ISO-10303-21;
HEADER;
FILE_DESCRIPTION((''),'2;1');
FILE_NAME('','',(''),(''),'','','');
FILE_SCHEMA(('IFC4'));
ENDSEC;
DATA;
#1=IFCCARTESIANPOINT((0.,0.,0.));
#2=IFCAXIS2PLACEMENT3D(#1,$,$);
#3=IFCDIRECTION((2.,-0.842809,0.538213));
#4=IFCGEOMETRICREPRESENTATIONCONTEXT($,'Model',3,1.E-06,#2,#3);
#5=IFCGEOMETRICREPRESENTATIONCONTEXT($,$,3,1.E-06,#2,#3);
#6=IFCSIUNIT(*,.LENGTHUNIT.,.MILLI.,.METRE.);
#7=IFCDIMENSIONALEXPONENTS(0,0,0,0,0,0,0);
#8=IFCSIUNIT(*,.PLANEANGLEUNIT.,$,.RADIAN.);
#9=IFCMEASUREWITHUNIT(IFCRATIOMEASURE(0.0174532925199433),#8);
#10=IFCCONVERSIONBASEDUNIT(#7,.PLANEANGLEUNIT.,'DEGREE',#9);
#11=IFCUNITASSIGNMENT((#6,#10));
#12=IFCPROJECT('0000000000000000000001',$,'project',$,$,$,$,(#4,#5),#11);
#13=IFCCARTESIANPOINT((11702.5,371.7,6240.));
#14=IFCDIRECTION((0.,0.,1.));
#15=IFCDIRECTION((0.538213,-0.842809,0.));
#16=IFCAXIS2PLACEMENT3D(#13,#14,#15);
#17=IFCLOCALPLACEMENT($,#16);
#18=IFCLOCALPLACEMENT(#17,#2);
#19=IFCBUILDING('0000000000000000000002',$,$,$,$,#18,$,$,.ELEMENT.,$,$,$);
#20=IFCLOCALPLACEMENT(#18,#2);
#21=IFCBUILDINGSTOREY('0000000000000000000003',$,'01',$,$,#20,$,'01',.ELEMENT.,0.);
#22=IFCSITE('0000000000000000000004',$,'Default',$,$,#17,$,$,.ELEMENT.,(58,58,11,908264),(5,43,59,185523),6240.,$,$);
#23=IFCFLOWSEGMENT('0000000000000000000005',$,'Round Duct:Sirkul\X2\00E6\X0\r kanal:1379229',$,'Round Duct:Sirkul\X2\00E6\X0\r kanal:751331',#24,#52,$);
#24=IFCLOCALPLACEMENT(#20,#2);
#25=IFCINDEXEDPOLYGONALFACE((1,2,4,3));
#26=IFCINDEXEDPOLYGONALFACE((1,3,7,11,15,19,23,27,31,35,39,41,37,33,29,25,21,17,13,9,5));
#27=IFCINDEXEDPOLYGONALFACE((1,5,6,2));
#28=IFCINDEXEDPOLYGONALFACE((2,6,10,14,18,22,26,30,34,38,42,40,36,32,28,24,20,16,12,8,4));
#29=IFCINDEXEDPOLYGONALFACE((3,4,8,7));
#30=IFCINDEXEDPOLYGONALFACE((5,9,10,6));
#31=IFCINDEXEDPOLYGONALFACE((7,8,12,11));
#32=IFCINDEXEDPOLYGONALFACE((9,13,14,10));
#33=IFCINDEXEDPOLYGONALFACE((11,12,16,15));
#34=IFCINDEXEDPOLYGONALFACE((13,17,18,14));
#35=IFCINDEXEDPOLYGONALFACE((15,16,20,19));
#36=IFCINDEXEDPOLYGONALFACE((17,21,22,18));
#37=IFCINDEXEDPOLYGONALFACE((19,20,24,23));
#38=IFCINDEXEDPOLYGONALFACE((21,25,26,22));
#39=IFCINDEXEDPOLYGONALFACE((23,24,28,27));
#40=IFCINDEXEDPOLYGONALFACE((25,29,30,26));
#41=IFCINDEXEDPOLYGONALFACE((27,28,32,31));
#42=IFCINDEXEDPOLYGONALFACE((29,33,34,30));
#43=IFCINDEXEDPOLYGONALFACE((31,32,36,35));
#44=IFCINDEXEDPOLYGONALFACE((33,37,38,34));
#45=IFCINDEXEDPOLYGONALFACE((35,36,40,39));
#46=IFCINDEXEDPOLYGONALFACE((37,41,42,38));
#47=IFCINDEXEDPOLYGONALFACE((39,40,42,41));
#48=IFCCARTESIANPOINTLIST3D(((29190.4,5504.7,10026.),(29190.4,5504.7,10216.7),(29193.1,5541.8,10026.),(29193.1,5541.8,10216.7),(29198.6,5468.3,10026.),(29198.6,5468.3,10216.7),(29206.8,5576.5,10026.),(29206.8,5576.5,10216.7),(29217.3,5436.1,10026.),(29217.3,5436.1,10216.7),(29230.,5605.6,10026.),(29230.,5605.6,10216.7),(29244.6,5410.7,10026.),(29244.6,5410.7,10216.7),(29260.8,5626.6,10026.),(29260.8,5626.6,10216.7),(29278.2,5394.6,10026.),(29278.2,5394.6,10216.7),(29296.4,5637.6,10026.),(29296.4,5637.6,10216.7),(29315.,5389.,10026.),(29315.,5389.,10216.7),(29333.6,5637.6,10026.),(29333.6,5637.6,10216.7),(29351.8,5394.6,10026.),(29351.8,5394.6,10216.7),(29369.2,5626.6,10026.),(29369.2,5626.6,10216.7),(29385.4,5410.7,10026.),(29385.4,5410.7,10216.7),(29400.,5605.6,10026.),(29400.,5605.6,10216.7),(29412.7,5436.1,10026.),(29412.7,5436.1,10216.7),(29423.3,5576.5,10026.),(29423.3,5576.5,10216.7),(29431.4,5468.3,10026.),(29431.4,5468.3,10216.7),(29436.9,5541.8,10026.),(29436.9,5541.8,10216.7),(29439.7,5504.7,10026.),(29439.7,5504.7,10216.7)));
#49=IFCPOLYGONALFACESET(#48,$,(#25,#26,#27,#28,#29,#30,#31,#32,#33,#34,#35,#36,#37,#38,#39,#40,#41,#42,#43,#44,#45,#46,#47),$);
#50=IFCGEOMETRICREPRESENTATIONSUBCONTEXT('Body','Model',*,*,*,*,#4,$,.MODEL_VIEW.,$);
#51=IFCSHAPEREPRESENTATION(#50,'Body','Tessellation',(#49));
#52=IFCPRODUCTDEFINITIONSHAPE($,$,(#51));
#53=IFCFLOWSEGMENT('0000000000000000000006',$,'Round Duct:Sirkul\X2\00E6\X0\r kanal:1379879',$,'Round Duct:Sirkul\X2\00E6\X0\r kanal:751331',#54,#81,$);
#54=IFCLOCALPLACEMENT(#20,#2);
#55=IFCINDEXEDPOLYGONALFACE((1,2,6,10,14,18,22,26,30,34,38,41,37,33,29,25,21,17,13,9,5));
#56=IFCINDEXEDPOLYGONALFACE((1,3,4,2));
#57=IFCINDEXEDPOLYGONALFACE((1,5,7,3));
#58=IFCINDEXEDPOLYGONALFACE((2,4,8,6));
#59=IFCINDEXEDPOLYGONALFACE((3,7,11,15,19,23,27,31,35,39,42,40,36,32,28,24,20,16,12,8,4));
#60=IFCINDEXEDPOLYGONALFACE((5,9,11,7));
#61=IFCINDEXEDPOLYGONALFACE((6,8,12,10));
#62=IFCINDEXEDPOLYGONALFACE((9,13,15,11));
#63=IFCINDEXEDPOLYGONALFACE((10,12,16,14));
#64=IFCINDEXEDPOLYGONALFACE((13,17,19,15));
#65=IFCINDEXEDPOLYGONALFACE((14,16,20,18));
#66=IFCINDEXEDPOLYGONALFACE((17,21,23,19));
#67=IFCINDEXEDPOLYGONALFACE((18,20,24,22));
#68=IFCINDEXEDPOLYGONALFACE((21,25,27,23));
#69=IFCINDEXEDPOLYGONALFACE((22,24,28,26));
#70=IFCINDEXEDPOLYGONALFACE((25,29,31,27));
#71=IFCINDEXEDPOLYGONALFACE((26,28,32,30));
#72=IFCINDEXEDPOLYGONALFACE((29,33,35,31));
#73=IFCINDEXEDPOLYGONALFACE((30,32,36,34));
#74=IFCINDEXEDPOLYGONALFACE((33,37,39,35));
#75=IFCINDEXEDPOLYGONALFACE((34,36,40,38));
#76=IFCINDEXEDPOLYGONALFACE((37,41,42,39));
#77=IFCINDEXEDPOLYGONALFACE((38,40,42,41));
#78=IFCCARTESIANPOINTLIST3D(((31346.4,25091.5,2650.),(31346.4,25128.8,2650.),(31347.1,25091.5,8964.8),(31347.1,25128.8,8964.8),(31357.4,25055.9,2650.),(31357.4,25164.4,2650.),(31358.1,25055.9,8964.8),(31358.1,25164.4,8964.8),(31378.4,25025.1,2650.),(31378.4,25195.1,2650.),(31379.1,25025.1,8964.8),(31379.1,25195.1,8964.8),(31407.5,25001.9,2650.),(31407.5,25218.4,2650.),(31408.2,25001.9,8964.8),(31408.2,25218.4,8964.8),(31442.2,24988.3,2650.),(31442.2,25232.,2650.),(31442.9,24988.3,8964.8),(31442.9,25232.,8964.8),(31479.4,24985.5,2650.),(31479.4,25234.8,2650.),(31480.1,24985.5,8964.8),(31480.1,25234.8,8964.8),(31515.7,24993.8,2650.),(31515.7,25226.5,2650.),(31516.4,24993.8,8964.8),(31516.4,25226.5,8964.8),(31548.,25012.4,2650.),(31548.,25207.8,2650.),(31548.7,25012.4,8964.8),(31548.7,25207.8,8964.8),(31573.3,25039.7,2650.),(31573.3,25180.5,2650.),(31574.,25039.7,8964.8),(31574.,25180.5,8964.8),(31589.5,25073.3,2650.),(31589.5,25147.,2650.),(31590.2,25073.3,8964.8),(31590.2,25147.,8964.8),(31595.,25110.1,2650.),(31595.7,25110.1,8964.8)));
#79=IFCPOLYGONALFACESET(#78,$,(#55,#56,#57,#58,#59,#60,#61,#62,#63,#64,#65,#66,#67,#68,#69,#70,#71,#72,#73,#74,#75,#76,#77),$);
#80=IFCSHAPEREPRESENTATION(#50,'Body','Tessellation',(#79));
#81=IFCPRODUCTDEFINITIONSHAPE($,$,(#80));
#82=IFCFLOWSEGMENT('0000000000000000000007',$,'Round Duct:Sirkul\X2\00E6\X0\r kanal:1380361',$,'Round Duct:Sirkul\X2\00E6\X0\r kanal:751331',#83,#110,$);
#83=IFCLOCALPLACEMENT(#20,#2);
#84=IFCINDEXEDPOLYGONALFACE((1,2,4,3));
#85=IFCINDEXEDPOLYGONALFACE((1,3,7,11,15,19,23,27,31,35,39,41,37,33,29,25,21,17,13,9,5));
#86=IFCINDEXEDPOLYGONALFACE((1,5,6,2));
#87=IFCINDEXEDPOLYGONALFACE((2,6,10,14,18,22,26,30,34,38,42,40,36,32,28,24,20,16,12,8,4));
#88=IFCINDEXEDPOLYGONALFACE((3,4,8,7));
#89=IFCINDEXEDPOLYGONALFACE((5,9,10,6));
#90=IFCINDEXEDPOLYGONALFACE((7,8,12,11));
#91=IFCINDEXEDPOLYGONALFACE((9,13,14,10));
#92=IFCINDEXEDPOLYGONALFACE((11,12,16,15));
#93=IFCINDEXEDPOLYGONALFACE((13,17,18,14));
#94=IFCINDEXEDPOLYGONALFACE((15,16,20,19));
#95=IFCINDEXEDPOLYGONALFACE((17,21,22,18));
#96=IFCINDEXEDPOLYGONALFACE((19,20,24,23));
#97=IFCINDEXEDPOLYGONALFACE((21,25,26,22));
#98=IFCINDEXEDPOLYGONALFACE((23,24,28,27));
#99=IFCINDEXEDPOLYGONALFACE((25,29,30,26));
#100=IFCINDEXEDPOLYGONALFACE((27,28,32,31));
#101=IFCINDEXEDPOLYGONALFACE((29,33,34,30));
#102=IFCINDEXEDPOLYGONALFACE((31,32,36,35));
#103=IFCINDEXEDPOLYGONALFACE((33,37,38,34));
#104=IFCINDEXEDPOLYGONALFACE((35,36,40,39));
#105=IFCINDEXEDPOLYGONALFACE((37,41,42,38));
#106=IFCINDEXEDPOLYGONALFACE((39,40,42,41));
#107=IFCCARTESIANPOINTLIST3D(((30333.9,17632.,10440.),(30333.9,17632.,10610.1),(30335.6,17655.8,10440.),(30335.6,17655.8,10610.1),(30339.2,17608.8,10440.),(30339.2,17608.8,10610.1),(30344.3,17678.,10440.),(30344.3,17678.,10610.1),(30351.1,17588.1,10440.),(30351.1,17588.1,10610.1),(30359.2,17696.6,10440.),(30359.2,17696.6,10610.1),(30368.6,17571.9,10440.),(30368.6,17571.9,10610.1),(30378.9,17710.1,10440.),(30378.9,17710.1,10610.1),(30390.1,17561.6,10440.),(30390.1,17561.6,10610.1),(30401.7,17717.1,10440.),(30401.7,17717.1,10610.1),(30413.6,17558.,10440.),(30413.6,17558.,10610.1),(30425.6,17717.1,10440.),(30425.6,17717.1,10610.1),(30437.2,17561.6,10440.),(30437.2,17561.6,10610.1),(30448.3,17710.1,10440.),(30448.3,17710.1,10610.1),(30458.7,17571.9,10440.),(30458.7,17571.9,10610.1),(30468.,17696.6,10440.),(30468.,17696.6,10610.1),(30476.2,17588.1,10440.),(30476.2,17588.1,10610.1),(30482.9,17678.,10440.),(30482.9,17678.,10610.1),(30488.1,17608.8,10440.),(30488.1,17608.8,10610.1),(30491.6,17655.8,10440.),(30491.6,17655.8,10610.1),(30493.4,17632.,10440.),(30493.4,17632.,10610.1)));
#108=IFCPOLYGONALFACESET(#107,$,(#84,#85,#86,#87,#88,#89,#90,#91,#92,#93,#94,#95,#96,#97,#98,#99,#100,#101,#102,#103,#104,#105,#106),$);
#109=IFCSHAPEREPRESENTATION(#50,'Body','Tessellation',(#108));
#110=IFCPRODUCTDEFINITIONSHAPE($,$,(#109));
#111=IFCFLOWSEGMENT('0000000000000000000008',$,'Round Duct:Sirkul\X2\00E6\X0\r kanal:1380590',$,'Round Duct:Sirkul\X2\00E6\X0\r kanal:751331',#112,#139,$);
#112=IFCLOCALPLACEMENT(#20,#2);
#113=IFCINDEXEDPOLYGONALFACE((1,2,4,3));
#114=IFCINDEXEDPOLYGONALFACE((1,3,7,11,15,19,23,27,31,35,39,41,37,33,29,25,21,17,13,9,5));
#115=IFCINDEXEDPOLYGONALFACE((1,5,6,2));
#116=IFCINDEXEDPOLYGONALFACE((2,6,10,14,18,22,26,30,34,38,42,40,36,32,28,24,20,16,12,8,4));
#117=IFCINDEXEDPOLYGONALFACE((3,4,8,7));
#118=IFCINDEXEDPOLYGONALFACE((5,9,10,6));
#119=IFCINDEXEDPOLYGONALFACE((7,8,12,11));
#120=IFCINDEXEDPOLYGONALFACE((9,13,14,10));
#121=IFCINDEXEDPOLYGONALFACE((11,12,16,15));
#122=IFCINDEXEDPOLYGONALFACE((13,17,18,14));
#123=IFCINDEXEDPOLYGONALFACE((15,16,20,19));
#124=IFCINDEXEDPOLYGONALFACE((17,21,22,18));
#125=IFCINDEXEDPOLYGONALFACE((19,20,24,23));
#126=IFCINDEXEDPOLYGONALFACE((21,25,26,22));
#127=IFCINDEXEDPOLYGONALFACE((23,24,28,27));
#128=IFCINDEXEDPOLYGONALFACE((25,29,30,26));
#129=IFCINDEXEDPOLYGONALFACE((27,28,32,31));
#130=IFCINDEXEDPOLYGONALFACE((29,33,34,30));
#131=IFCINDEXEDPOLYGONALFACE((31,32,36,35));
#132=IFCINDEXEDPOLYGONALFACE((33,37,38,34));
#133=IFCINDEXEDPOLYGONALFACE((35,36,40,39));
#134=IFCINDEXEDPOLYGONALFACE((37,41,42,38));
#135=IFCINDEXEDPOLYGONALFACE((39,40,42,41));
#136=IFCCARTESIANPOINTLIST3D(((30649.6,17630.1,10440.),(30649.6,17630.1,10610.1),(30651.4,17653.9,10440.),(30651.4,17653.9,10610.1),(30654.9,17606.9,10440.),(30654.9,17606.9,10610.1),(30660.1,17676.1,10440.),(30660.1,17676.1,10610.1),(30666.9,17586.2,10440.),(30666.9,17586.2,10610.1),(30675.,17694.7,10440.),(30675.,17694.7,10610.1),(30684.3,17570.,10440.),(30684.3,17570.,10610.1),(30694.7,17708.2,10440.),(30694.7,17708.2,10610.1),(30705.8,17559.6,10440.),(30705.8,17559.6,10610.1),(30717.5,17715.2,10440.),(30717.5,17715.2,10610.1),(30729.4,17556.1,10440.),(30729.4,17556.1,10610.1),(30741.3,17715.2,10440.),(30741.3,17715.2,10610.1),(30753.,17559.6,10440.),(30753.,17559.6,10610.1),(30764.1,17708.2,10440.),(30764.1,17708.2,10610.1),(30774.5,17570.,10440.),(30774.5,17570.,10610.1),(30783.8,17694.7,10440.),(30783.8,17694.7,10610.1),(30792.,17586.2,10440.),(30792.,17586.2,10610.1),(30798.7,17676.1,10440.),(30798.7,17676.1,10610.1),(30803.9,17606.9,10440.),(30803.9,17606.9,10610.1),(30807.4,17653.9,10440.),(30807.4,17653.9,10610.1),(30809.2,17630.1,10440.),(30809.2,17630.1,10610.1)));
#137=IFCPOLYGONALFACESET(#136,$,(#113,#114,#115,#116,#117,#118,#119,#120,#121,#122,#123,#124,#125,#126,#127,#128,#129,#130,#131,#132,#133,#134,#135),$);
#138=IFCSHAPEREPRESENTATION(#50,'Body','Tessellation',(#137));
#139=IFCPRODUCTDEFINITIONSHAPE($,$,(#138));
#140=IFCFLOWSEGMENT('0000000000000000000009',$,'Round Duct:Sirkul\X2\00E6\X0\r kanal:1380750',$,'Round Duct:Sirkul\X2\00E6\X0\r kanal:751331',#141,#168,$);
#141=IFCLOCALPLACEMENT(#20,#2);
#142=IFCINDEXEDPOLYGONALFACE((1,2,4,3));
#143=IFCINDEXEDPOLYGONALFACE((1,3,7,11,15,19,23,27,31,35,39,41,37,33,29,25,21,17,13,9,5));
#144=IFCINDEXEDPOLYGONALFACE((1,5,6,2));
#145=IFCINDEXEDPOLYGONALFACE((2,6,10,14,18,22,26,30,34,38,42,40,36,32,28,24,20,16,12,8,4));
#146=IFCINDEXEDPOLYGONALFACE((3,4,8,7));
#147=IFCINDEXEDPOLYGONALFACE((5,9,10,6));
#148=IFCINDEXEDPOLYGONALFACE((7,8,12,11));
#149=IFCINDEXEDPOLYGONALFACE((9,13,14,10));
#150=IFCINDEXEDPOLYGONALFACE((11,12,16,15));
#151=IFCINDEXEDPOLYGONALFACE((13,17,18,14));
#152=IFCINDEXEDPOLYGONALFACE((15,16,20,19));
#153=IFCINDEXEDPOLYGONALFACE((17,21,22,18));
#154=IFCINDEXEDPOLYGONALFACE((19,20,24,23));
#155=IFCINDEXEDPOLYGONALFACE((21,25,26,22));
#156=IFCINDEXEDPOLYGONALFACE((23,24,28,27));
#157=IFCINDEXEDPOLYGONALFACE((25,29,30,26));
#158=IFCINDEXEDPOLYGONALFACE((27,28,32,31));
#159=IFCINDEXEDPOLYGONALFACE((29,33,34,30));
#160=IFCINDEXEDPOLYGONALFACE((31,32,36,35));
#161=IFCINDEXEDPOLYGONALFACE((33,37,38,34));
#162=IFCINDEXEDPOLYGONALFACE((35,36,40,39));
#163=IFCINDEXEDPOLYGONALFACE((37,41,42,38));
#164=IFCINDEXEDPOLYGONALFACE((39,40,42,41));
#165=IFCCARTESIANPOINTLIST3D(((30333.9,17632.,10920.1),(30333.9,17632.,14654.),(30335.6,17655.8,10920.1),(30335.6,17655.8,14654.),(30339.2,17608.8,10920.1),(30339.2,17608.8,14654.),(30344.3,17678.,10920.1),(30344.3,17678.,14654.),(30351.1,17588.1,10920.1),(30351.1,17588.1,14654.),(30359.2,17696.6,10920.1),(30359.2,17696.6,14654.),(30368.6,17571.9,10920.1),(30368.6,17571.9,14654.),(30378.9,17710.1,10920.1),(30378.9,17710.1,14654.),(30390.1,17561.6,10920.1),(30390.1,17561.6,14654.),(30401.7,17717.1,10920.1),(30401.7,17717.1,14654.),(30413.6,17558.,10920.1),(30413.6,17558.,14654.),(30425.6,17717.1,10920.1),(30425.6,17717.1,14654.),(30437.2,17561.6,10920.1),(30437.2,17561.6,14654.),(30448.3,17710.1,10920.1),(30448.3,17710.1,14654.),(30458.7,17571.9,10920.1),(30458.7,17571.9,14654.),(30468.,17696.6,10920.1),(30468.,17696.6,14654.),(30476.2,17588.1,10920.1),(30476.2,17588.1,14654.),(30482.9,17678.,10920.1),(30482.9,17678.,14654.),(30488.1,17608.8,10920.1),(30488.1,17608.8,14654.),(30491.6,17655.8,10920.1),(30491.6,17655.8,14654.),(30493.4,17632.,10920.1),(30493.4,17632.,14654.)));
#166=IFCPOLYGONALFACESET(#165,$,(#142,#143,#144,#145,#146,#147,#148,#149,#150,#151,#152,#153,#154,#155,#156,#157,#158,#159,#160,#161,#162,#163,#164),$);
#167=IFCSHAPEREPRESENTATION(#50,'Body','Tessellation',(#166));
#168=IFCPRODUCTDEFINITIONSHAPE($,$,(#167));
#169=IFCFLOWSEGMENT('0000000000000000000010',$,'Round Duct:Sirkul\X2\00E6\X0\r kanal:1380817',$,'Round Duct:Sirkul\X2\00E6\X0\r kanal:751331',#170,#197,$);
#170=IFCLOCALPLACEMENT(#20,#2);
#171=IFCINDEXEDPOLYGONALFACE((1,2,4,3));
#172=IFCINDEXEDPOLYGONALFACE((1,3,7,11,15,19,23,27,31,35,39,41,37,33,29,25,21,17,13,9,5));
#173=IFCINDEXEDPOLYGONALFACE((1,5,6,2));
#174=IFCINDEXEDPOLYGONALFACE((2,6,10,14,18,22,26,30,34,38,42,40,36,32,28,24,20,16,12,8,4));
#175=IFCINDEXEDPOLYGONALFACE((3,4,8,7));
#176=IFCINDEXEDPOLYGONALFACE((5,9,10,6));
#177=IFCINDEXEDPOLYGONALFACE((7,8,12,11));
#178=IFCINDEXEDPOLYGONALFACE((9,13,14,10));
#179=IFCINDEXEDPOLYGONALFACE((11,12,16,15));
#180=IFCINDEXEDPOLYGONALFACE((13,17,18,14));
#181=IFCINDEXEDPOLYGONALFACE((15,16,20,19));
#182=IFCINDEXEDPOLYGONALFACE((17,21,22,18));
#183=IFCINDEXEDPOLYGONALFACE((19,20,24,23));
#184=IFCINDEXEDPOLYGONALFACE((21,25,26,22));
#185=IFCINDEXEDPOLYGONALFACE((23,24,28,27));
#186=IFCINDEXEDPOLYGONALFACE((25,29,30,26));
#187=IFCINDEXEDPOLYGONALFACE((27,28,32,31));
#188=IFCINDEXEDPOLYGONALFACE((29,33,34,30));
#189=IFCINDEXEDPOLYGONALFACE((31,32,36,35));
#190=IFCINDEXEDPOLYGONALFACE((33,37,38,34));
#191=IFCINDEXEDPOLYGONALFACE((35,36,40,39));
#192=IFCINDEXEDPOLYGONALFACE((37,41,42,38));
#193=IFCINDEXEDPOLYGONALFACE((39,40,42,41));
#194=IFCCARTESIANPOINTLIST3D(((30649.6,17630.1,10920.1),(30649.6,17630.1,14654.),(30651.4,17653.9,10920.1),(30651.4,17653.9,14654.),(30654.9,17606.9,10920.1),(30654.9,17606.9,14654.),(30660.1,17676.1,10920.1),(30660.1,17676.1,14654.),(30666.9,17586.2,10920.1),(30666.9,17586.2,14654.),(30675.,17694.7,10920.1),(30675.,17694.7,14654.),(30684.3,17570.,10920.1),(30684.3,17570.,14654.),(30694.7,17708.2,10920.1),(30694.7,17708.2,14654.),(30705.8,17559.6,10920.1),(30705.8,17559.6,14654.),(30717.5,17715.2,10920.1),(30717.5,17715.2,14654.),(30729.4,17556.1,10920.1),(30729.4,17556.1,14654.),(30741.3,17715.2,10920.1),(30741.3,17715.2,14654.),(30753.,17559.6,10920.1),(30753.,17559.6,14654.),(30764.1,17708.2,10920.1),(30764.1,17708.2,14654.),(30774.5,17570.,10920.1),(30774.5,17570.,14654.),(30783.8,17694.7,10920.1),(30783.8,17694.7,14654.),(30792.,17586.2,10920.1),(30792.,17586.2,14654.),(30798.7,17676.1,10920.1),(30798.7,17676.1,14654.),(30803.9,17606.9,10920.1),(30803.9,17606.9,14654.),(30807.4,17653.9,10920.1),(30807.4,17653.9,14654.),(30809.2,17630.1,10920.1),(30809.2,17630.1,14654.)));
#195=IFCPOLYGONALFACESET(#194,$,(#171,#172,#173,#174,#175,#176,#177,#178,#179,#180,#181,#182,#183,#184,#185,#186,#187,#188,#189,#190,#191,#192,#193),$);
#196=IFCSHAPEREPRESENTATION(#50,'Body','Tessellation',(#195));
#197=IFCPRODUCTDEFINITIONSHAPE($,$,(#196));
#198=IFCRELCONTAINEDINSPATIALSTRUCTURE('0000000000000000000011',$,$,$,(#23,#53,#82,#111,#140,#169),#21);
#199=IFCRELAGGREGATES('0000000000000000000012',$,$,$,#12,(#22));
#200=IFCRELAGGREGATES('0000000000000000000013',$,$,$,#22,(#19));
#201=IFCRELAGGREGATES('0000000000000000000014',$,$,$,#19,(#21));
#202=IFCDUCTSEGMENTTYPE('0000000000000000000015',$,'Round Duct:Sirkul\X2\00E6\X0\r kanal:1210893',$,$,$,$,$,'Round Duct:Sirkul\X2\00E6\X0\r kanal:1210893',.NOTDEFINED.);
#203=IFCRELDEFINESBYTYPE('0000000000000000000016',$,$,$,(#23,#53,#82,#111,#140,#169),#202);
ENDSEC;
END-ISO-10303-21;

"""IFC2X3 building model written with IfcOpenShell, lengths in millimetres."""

from ifc_helpers import new_model, entity, si_unit, converted_unit, direction, frame, frame_2d, origin, origin_2d_with_axis, place, context, subcontext, project, spatial, circle, extrude, type_object, element, save


model = new_model("IFC2X3")

# Units and contexts
model_context = context("Model", 3, precision=1e-06, world=origin(), true_north=direction((2.0, -0.842809, 0.538213)))
context_of_model = context(None, 3, precision=1e-06, world=origin(), true_north=direction((2.0, -0.842809, 0.538213)))
body_context = subcontext(model_context, "Body", "Model", "MODEL_VIEW")
ifc_project = project(units=[si_unit("LENGTHUNIT", "METRE", prefix="MILLI"), converted_unit("PLANEANGLEUNIT", "DEGREE", entity("IfcRatioMeasure", 0.0174532925199433), si_unit("PLANEANGLEUNIT", "RADIAN"), dimensions=[0, 0, 0, 0, 0, 0, 0])], contexts=[model_context, context_of_model])

# Site, building, storey
site_placement = place(None, frame((11702.5, 371.7, 6240.0), z_axis=(0.0, 0.0, 1.0), x_axis=(0.538213, -0.842809, 0.0)))
site = spatial("IfcSite", under=ifc_project, at=site_placement, Name="Default", CompositionType="ELEMENT", RefLatitude=(58, 58, 11, 908264), RefLongitude=(5, 43, 59, 185523), RefElevation=6240.0)
building_placement = place(site_placement, origin())
building = spatial("IfcBuilding", under=site, at=building_placement, CompositionType="ELEMENT")
storey_placement = place(building_placement, origin())
storey = spatial("IfcBuildingStorey", under=building, at=storey_placement, Name="01", LongName="01", CompositionType="ELEMENT", Elevation=0.0)

# Flow segments
duct_segment_type_1 = type_object("IfcDuctSegmentType", Name="Round Duct:Sirkulær kanal:1210893", ElementType="Round Duct:Sirkulær kanal:1210893", PredefinedType="NOTDEFINED")
flow_segment_1_placement = place(storey_placement, origin())
element("IfcFlowSegment", 1, at=flow_segment_1_placement, inside=storey, type_object=duct_segment_type_1, Name="Round Duct:Sirkulær kanal:1379229", ObjectType="Round Duct:Sirkulær kanal:751331", context=body_context, shape_type="SweptSolid", body=[
    extrude(circle(Radius=125.0, at=frame_2d((0.0, 0.0), x_axis=(1.0, 0.0))), frame((29315.0, 5514.0, 10026.0), z_axis=(0.0, 0.0, 1.0), x_axis=(0.0, -1.0, 0.0)), (0.0, 0.0, 1.0), 190.7),
])
flow_segment_2_placement = place(storey_placement, origin())
element("IfcFlowSegment", 2, at=flow_segment_2_placement, inside=storey, type_object=duct_segment_type_1, Name="Round Duct:Sirkulær kanal:1379879", ObjectType="Round Duct:Sirkulær kanal:751331", context=body_context, shape_type="SweptSolid", body=[
    extrude(circle(Radius=125.0, at=frame_2d((0.0, 0.0), x_axis=(1.0, 0.0))), frame((31470.0, 25110.1, 2650.0), z_axis=(0.000106, 0.0, 1.0), x_axis=(1.0, 0.0, -0.000106)), (0.0, 0.0, 1.0), 6314.8),
])
flow_segment_3_placement = place(storey_placement, origin())
element("IfcFlowSegment", 3, at=flow_segment_3_placement, inside=storey, type_object=duct_segment_type_1, Name="Round Duct:Sirkulær kanal:1380361", ObjectType="Round Duct:Sirkulær kanal:751331", context=body_context, shape_type="SweptSolid", body=[
    extrude(circle(Radius=80.0, at=origin_2d_with_axis()), frame((30413.6, 17638.0, 10440.0), z_axis=(0.0, 0.0, 1.0), x_axis=(0.0, -1.0, 0.0)), (0.0, 0.0, 1.0), 170.1),
])
flow_segment_4_placement = place(storey_placement, origin())
element("IfcFlowSegment", 4, at=flow_segment_4_placement, inside=storey, type_object=duct_segment_type_1, Name="Round Duct:Sirkulær kanal:1380590", ObjectType="Round Duct:Sirkulær kanal:751331", context=body_context, shape_type="SweptSolid", body=[
    extrude(circle(Radius=80.0, at=origin_2d_with_axis()), frame((30729.4, 17636.1, 10440.0), z_axis=(0.0, 0.0, 1.0), x_axis=(0.0, -1.0, 0.0)), (0.0, 0.0, 1.0), 170.1),
])
flow_segment_5_placement = place(storey_placement, origin())
element("IfcFlowSegment", 5, at=flow_segment_5_placement, inside=storey, type_object=duct_segment_type_1, Name="Round Duct:Sirkulær kanal:1380750", ObjectType="Round Duct:Sirkulær kanal:751331", context=body_context, shape_type="SweptSolid", body=[
    extrude(circle(Radius=80.0, at=frame_2d((0.0, 0.0), x_axis=(1.0, 0.0))), frame((30413.6, 17638.0, 10920.1), z_axis=(0.0, 0.0, 1.0), x_axis=(0.0, -1.0, 0.0)), (0.0, 0.0, 1.0), 3733.9),
])
flow_segment_6_placement = place(storey_placement, origin())
element("IfcFlowSegment", 6, at=flow_segment_6_placement, inside=storey, type_object=duct_segment_type_1, Name="Round Duct:Sirkulær kanal:1380817", ObjectType="Round Duct:Sirkulær kanal:751331", context=body_context, shape_type="SweptSolid", body=[
    extrude(circle(Radius=80.0, at=frame_2d((0.0, 0.0), x_axis=(1.0, 0.0))), frame((30729.4, 17636.1, 10920.1), z_axis=(0.0, 0.0, 1.0), x_axis=(0.0, -1.0, 0.0)), (0.0, 0.0, 1.0), 3733.9),
])

save(model, "model.ifc")
